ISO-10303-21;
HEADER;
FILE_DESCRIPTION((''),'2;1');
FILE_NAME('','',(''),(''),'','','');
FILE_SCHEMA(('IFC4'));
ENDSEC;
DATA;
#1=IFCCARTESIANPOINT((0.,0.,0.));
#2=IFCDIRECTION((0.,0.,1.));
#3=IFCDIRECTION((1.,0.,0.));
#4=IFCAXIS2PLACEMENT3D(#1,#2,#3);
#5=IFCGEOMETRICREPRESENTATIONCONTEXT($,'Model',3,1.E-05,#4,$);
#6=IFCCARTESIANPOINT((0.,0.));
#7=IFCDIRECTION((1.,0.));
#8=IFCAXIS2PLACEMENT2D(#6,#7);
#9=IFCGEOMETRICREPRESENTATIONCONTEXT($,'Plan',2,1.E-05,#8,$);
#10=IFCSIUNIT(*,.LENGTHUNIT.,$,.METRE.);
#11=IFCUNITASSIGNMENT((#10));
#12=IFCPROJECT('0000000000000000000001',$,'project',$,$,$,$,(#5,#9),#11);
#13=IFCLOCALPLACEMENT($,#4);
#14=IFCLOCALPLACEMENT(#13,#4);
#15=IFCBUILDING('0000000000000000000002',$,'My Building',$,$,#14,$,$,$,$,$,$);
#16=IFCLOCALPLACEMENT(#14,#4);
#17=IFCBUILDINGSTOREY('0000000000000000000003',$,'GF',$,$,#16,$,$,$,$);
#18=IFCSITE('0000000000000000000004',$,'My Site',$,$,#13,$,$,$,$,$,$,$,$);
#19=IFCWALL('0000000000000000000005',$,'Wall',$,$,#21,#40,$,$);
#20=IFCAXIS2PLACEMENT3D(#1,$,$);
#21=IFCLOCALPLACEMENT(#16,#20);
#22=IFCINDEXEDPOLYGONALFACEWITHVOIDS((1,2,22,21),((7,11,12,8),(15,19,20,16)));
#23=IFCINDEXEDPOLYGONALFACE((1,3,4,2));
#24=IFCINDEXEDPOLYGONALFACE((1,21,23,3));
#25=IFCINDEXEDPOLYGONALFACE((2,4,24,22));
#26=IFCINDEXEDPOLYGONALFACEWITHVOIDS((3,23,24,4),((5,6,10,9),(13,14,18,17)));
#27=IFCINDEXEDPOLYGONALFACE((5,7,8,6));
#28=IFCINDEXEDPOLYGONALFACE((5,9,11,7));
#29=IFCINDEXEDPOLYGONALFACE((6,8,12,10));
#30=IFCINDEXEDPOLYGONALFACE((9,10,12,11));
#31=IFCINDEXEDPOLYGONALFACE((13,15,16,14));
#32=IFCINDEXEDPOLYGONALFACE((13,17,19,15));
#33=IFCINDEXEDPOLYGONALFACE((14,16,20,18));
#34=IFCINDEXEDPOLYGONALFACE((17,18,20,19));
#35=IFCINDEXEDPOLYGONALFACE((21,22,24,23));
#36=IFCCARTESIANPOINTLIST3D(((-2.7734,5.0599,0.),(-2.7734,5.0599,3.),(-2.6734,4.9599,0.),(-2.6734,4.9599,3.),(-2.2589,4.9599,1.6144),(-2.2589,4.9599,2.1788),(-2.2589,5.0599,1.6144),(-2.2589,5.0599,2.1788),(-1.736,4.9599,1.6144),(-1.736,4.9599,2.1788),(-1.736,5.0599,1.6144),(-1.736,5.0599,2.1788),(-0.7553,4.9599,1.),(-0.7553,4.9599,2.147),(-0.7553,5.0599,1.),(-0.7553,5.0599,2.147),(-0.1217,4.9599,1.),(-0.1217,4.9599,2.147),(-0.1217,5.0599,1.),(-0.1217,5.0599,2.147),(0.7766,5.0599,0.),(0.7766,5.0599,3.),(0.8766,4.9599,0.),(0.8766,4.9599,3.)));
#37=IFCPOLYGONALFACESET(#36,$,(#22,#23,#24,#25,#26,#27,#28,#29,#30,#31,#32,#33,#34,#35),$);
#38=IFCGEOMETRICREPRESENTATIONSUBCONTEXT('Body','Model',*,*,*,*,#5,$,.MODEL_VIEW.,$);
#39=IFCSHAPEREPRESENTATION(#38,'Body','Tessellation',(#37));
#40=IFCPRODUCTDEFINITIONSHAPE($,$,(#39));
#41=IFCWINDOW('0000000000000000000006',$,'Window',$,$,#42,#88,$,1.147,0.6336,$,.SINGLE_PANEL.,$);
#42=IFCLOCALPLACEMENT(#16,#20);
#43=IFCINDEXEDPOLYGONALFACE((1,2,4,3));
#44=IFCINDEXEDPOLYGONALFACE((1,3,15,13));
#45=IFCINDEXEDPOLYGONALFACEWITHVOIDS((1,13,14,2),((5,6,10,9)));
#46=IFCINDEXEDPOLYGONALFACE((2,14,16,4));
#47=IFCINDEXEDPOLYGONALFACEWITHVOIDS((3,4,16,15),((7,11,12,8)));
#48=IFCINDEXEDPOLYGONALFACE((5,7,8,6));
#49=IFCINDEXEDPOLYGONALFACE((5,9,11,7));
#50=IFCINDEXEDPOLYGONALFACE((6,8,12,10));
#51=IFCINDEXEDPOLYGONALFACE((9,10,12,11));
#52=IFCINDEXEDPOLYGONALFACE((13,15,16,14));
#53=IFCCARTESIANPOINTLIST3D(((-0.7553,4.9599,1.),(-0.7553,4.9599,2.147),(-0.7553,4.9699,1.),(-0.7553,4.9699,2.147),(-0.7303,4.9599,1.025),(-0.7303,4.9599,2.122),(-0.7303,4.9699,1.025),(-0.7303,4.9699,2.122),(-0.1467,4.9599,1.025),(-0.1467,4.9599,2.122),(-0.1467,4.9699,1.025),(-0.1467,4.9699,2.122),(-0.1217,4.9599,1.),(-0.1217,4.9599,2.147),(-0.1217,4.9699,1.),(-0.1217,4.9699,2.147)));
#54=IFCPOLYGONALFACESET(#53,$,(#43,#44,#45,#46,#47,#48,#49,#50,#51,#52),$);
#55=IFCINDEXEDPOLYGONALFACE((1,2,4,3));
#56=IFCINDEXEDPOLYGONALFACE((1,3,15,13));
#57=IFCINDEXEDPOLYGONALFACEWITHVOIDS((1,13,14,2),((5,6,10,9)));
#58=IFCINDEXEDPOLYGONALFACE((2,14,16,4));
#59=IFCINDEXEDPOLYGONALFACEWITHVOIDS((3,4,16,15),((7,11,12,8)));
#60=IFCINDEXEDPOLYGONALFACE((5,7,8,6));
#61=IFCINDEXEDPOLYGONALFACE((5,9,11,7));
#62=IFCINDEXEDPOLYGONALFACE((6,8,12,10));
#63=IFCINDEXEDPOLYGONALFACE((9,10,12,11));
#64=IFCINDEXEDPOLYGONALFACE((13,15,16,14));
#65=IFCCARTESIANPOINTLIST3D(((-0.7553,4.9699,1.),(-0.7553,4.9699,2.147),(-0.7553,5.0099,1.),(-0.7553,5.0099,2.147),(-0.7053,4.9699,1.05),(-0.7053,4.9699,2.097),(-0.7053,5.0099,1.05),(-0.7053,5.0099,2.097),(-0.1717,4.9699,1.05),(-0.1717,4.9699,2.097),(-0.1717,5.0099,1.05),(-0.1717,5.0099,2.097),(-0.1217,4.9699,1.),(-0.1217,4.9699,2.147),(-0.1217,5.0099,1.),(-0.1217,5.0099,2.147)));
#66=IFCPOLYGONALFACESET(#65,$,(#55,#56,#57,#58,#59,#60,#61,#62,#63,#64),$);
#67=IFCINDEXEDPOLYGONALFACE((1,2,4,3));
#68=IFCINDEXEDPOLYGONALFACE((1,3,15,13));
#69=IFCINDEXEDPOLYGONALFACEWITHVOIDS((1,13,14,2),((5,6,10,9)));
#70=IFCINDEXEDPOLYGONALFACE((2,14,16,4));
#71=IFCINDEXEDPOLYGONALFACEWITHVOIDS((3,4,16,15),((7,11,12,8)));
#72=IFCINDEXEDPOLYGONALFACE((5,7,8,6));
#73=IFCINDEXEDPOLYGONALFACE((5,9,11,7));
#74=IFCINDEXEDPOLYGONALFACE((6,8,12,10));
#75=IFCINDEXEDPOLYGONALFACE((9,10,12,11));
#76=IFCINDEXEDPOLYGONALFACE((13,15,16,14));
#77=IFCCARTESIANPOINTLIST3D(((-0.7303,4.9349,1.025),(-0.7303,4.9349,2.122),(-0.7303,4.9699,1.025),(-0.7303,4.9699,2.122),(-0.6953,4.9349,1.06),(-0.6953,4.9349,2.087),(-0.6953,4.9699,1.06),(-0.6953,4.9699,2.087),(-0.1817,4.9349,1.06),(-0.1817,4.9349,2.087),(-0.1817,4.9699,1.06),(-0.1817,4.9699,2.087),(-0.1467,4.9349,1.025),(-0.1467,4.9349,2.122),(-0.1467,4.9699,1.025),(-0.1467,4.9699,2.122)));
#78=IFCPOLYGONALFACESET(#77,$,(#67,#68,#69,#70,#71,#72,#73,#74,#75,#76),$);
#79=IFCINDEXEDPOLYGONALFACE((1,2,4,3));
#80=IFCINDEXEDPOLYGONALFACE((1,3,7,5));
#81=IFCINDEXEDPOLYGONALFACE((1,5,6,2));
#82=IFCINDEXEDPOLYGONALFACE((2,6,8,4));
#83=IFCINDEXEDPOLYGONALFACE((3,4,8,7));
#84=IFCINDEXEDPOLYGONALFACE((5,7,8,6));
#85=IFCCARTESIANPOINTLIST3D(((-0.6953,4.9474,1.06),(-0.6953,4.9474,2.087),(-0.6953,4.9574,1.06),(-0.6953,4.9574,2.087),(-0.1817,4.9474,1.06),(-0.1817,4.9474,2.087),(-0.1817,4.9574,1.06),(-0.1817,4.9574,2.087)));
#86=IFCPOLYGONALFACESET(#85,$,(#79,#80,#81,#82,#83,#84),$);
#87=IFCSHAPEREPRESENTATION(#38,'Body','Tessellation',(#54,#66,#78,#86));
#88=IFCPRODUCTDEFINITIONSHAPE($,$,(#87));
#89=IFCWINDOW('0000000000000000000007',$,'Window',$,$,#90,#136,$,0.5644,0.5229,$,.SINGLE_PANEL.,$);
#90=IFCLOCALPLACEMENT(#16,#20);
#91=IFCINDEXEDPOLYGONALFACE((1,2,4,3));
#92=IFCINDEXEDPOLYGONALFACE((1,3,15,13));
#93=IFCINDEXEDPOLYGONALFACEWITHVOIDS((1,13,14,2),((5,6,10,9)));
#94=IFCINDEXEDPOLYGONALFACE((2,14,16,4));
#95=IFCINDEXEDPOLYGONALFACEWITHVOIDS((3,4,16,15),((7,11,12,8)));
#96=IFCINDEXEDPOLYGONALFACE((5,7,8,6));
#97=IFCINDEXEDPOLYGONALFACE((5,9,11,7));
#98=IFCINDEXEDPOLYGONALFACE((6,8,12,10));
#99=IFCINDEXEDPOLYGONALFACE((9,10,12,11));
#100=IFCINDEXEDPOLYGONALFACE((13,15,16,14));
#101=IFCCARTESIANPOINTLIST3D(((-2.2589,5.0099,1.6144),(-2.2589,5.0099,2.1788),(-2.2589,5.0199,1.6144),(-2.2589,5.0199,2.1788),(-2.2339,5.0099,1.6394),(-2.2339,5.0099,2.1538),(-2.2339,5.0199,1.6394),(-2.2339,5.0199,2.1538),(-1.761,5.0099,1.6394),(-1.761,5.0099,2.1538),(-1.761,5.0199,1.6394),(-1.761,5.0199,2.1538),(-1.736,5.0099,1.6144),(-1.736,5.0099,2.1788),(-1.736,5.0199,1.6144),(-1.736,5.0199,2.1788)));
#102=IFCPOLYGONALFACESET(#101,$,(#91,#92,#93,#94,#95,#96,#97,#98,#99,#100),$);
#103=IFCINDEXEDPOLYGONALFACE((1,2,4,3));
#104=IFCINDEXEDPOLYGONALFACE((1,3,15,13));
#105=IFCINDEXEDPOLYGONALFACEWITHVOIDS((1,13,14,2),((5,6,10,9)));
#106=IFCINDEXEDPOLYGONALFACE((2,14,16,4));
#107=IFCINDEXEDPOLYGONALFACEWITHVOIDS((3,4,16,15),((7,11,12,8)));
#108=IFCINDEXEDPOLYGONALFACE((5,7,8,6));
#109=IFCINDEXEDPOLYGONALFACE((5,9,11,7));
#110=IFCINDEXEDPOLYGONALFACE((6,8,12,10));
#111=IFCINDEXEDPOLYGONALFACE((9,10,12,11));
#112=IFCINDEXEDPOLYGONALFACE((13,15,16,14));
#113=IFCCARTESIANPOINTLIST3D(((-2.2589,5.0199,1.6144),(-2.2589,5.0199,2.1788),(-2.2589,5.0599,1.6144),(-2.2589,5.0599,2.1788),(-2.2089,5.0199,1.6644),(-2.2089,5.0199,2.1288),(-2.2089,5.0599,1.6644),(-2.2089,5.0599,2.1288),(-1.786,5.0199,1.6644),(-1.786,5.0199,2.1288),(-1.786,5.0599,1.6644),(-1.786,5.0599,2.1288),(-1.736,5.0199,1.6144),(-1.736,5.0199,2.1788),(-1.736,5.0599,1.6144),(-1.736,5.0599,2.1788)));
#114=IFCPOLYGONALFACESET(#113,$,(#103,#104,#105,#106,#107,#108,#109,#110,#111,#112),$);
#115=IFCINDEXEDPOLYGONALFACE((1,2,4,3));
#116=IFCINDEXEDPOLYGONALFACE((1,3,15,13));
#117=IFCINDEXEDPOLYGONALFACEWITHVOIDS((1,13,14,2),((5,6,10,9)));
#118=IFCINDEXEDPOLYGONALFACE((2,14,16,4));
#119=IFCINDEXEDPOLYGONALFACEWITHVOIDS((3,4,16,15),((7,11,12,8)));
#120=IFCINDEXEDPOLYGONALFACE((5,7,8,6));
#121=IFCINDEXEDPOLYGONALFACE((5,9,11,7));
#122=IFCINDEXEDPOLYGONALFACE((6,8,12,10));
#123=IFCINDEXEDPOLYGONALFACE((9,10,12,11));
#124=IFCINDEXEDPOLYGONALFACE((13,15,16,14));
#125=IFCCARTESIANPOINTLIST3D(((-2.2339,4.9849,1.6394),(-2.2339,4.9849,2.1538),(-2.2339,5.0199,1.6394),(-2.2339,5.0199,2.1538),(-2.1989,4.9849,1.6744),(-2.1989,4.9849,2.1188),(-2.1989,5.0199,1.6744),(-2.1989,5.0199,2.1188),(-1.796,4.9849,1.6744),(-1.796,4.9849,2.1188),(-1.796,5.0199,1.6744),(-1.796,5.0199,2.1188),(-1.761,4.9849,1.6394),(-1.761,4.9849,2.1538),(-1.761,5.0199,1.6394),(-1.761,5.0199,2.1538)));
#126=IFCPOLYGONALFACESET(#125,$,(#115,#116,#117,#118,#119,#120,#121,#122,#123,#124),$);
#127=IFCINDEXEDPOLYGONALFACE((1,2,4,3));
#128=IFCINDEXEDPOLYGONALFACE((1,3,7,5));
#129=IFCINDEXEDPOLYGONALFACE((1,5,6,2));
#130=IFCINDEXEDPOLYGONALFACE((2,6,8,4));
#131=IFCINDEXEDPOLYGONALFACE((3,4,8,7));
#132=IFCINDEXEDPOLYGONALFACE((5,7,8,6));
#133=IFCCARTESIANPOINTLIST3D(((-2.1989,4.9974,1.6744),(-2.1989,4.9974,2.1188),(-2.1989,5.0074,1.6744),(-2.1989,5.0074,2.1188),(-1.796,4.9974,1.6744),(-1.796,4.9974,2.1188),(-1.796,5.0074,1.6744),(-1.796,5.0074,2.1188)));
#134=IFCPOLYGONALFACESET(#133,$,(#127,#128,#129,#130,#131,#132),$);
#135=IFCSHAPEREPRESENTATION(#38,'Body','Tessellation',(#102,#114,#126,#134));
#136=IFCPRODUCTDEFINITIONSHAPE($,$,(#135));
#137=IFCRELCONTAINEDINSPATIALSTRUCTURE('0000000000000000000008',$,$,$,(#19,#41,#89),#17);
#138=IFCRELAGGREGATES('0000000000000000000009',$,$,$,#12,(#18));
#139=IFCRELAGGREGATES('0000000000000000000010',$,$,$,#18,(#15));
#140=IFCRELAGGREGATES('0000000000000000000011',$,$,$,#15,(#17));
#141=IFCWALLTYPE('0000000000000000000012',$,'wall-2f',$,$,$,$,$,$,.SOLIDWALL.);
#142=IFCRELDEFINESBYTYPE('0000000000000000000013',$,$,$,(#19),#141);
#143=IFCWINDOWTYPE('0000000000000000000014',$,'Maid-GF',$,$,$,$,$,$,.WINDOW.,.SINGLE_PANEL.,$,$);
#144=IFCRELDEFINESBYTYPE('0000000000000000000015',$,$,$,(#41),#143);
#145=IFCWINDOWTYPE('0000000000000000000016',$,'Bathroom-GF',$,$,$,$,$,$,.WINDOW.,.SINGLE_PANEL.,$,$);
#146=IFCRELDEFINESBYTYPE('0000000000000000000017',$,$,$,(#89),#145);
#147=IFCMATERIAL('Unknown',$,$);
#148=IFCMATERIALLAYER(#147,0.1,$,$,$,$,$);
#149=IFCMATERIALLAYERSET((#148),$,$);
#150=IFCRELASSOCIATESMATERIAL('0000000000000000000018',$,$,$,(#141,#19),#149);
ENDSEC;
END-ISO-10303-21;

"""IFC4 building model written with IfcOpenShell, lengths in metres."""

from ifc_helpers import new_model, entity, si_unit, frame, origin_with_axes, origin_2d_with_axis, place, context, subcontext, project, spatial, line, indexed_curve, outline, extrude, shape, source, transform, mapped, material, layer, layer_set, layer_usage, type_object, type_shapes, element, fill, save


model = new_model("IFC4")

# Units and contexts
model_context = context("Model", 3, precision=1e-05, world=origin_with_axes())
plan_context = context("Plan", 2, precision=1e-05, world=origin_2d_with_axis())
body_context_1 = subcontext(model_context, "Body", "Model", "MODEL_VIEW")
body_context_2 = subcontext(plan_context, "Body", "Plan", "PLAN_VIEW")
ifc_project = project(units=[si_unit("LENGTHUNIT", "METRE")], contexts=[model_context, plan_context])

# Site, building, storey
site_placement = place(None, origin_with_axes())
site = spatial("IfcSite", under=ifc_project, at=site_placement, Name="My Site")
building_placement = place(site_placement, origin_with_axes())
building = spatial("IfcBuilding", under=site, at=building_placement, Name="My Building")
storey_placement = place(building_placement, origin_with_axes())
storey = spatial("IfcBuildingStorey", under=building, at=storey_placement, Name="GF")

# Shared definitions
ifc_material = material(Name="Unknown")

# Shared definitions
ifc_layer_1 = layer(ifc_material, 0.1)
ifc_layer_set_1 = layer_set([ifc_layer_1])
wall_type = type_object("IfcWallType", Name="wall-2f", PredefinedType="SOLIDWALL", material=ifc_layer_set_1)

# Wall, openings, windows
ifc_layer_usage_1 = layer_usage(ifc_layer_set_1, "AXIS2", "POSITIVE", 0.0)
wall_1_placement = place(storey_placement, frame((0.7766, 5.0599, 0.0), z_axis=(0.0, 0.0, 1.0), x_axis=(-1.0, 0.0, 0.0)))
wall_1 = element("IfcWall", 1, at=wall_1_placement, inside=storey, type_object=wall_type, material=ifc_layer_usage_1, Name="Wall", context=body_context_1, shape_type="SweptSolid", body=[
    extrude(outline(indexed_curve([(0.0, 0.0), (-0.1, 0.1), (3.45, 0.1), (3.55, 0.0)], segments=[line(1, 2, 3, 4, 1)])), origin_with_axes(), (0.0, 0.0, 1.0), 3.0),
])
shared_shape_1 = source(origin_with_axes(), body_context_1, "Body", "SweptSolid", [
    extrude(outline(indexed_curve([(0.0, 0.0), (0.6336, 0.0), (0.6336, 1.147), (0.0, 1.147)], segments=[line(1, 2, 3, 4, 1)])), frame((0.0, -0.6, 0.0), z_axis=(0.0, -1.0, 0.0), x_axis=(1.0, 0.0, 0.0)), (0.0, 0.0, -1.0), 1.2),
])
opening_1_placement = place(wall_1_placement, frame((0.8983, 0.0, 1.0), z_axis=(0.0, 0.0, 1.0), x_axis=(1.0, 0.0, 0.0)))
opening_1 = element("IfcOpeningElement", 2, at=opening_1_placement, cuts=wall_1, PredefinedType="OPENING", context=body_context_1, shape_type="MappedRepresentation", body=[
    mapped(shared_shape_1, transform((0.0, 0.0, 0.0), x_axis=(1.0, 0.0, 0.0), y_axis=(0.0, 1.0, 0.0), z_axis=(0.0, 0.0, 1.0), scale=1.0)),
])
shared_shape_2 = source(origin_with_axes(), body_context_1, "Body", "SweptSolid", [
    extrude(outline(indexed_curve([(0.0, 0.0), (0.5229, 0.0), (0.5229, 0.5644), (0.0, 0.5644)], segments=[line(1, 2, 3, 4, 1)])), frame((0.0, -0.6, 0.0), z_axis=(0.0, -1.0, 0.0), x_axis=(1.0, 0.0, 0.0)), (0.0, 0.0, -1.0), 1.2),
])
opening_2_placement = place(wall_1_placement, frame((2.5126, -0.05, 1.6144), z_axis=(0.0, 0.0, 1.0), x_axis=(1.0, 0.0, 0.0)))
opening_2 = element("IfcOpeningElement", 3, at=opening_2_placement, cuts=wall_1, PredefinedType="OPENING", context=body_context_1, shape_type="MappedRepresentation", body=[
    mapped(shared_shape_2, transform((0.0, 0.0, 0.0), x_axis=(1.0, 0.0, 0.0), y_axis=(0.0, 1.0, 0.0), z_axis=(0.0, 0.0, 1.0), scale=1.0)),
])
window_type_1 = type_object("IfcWindowType", Name="Maid-GF", PartitioningType="SINGLE_PANEL", PredefinedType="WINDOW")
shared_shape_3 = source(origin_with_axes(), body_context_1, "Body", "SweptSolid", [
    extrude(outline(indexed_curve([(0.0, 0.0), (0.6336, 0.0), (0.6336, 1.147), (0.0, 1.147)], segments=[line(1, 2, 3, 4, 1)]), holes=[indexed_curve([(0.025, 0.025), (0.6086, 0.025), (0.6086, 1.122), (0.025, 1.122)], segments=[line(1, 2, 3, 4, 1)])]), frame((0.0, 0.09, 0.0), z_axis=(0.0, -1.0, 0.0), x_axis=(1.0, 0.0, 0.0)), (0.0, 0.0, -1.0), 0.01),
    extrude(outline(indexed_curve([(0.0, 0.0), (0.6336, 0.0), (0.6336, 1.147), (0.0, 1.147)], segments=[line(1, 2, 3, 4, 1)]), holes=[indexed_curve([(0.05, 0.05), (0.5836, 0.05), (0.5836, 1.097), (0.05, 1.097)], segments=[line(1, 2, 3, 4, 1)])]), frame((0.0, 0.05, 0.0), z_axis=(0.0, -1.0, 0.0), x_axis=(1.0, 0.0, 0.0)), (0.0, 0.0, -1.0), 0.04),
    extrude(outline(indexed_curve([(0.0, 0.0), (0.5836, 0.0), (0.5836, 1.097), (0.0, 1.097)], segments=[line(1, 2, 3, 4, 1)]), holes=[indexed_curve([(0.035, 0.035), (0.5486, 0.035), (0.5486, 1.062), (0.035, 1.062)], segments=[line(1, 2, 3, 4, 1)])]), frame((0.025, 0.09, 0.025), z_axis=(0.0, -1.0, 0.0), x_axis=(1.0, 0.0, 0.0)), (0.0, 0.0, -1.0), 0.035),
    extrude(outline(indexed_curve([(0.035, 0.035), (0.5486, 0.035), (0.5486, 1.062), (0.035, 1.062)], segments=[line(1, 2, 3, 4, 1)])), frame((0.025, 0.1025, 0.025), z_axis=(0.0, -1.0, 0.0), x_axis=(1.0, 0.0, 0.0)), (0.0, 0.0, -1.0), 0.01),
])
shared_shape_4 = source(origin_with_axes(), body_context_2, "Body", "Curve2D", [
    entity("IfcIndexedPolyCurve", entity("IfcCartesianPointList2D", [[0.05, 0.05], [0.5836, 0.05]])),
    entity("IfcIndexedPolyCurve", entity("IfcCartesianPointList2D", [[0.0, 0.1], [0.025, 0.1], [0.025, 0.09], [0.05, 0.09], [0.05, 0.05], [0.0, 0.05]]), [entity("IfcLineIndex", [1, 2, 3, 4, 5, 6, 1])]),
    entity("IfcIndexedPolyCurve", entity("IfcCartesianPointList2D", [[0.6336, 0.1], [0.6086, 0.1], [0.6086, 0.09], [0.5836, 0.09], [0.5836, 0.05], [0.6336, 0.05]]), [entity("IfcLineIndex", [1, 2, 3, 4, 5, 6, 1])]),
    entity("IfcIndexedPolyCurve", entity("IfcCartesianPointList2D", [[0.025, 0.09], [0.06, 0.09], [0.06, 0.125], [0.025, 0.125]]), [entity("IfcLineIndex", [1, 2, 3, 4, 1])]),
    entity("IfcIndexedPolyCurve", entity("IfcCartesianPointList2D", [[0.6086, 0.09], [0.5736, 0.09], [0.5736, 0.125], [0.6086, 0.125]]), [entity("IfcLineIndex", [1, 2, 3, 4, 1])]),
    entity("IfcIndexedPolyCurve", entity("IfcCartesianPointList2D", [[0.06, 0.09], [0.5736, 0.09]])),
    entity("IfcIndexedPolyCurve", entity("IfcCartesianPointList2D", [[0.06, 0.125], [0.5736, 0.125]])),
    entity("IfcIndexedPolyCurve", entity("IfcCartesianPointList2D", [[0.06, 0.1075], [0.5736, 0.1075]])),
])
type_shapes(window_type_1, [shared_shape_3, shared_shape_4])
window_1_placement = place(opening_1_placement, frame((0.0, 0.0, 0.0), z_axis=(0.0, 0.0, 1.0), x_axis=(1.0, 0.0, 0.0)))
window_1 = element("IfcWindow", 4, at=window_1_placement, inside=storey, type_object=window_type_1, Name="Window", OverallHeight=1.147, OverallWidth=0.6336, PartitioningType="SINGLE_PANEL", shapes=[
    shape(body_context_1, "Body", "MappedRepresentation", [mapped(shared_shape_3, transform((0.0, 0.0, 0.0), x_axis=(1.0, 0.0, 0.0), y_axis=(0.0, 1.0, 0.0), z_axis=(0.0, 0.0, 1.0), scale=1.0))]),
    shape(body_context_2, "Body", "MappedRepresentation", [mapped(shared_shape_4, transform((0.0, 0.0, 0.0), x_axis=(1.0, 0.0, 0.0), y_axis=(0.0, 1.0, 0.0), z_axis=(0.0, 0.0, 1.0), scale=1.0))]),
])
fill(opening_1, window_1)
window_type_2 = type_object("IfcWindowType", Name="Bathroom-GF", PartitioningType="SINGLE_PANEL", PredefinedType="WINDOW")
shared_shape_5 = source(origin_with_axes(), body_context_1, "Body", "SweptSolid", [
    extrude(outline(indexed_curve([(0.0, 0.0), (0.5229, 0.0), (0.5229, 0.5644), (0.0, 0.5644)], segments=[line(1, 2, 3, 4, 1)]), holes=[indexed_curve([(0.025, 0.025), (0.4979, 0.025), (0.4979, 0.5394), (0.025, 0.5394)], segments=[line(1, 2, 3, 4, 1)])]), frame((0.0, 0.09, 0.0), z_axis=(0.0, -1.0, 0.0), x_axis=(1.0, 0.0, 0.0)), (0.0, 0.0, -1.0), 0.01),
    extrude(outline(indexed_curve([(0.0, 0.0), (0.5229, 0.0), (0.5229, 0.5644), (0.0, 0.5644)], segments=[line(1, 2, 3, 4, 1)]), holes=[indexed_curve([(0.05, 0.05), (0.4729, 0.05), (0.4729, 0.5144), (0.05, 0.5144)], segments=[line(1, 2, 3, 4, 1)])]), frame((0.0, 0.05, 0.0), z_axis=(0.0, -1.0, 0.0), x_axis=(1.0, 0.0, 0.0)), (0.0, 0.0, -1.0), 0.04),
    extrude(outline(indexed_curve([(0.0, 0.0), (0.4729, 0.0), (0.4729, 0.5144), (0.0, 0.5144)], segments=[line(1, 2, 3, 4, 1)]), holes=[indexed_curve([(0.035, 0.035), (0.4379, 0.035), (0.4379, 0.4794), (0.035, 0.4794)], segments=[line(1, 2, 3, 4, 1)])]), frame((0.025, 0.09, 0.025), z_axis=(0.0, -1.0, 0.0), x_axis=(1.0, 0.0, 0.0)), (0.0, 0.0, -1.0), 0.035),
    extrude(outline(indexed_curve([(0.035, 0.035), (0.4379, 0.035), (0.4379, 0.4794), (0.035, 0.4794)], segments=[line(1, 2, 3, 4, 1)])), frame((0.025, 0.1025, 0.025), z_axis=(0.0, -1.0, 0.0), x_axis=(1.0, 0.0, 0.0)), (0.0, 0.0, -1.0), 0.01),
])
shared_shape_6 = source(origin_with_axes(), body_context_2, "Body", "Curve2D", [
    entity("IfcIndexedPolyCurve", entity("IfcCartesianPointList2D", [[0.05, 0.05], [0.4729, 0.05]])),
    entity("IfcIndexedPolyCurve", entity("IfcCartesianPointList2D", [[0.0, 0.1], [0.025, 0.1], [0.025, 0.09], [0.05, 0.09], [0.05, 0.05], [0.0, 0.05]]), [entity("IfcLineIndex", [1, 2, 3, 4, 5, 6, 1])]),
    entity("IfcIndexedPolyCurve", entity("IfcCartesianPointList2D", [[0.5229, 0.1], [0.4979, 0.1], [0.4979, 0.09], [0.4729, 0.09], [0.4729, 0.05], [0.5229, 0.05]]), [entity("IfcLineIndex", [1, 2, 3, 4, 5, 6, 1])]),
    entity("IfcIndexedPolyCurve", entity("IfcCartesianPointList2D", [[0.025, 0.09], [0.06, 0.09], [0.06, 0.125], [0.025, 0.125]]), [entity("IfcLineIndex", [1, 2, 3, 4, 1])]),
    entity("IfcIndexedPolyCurve", entity("IfcCartesianPointList2D", [[0.4979, 0.09], [0.4629, 0.09], [0.4629, 0.125], [0.4979, 0.125]]), [entity("IfcLineIndex", [1, 2, 3, 4, 1])]),
    entity("IfcIndexedPolyCurve", entity("IfcCartesianPointList2D", [[0.06, 0.09], [0.4629, 0.09]])),
    entity("IfcIndexedPolyCurve", entity("IfcCartesianPointList2D", [[0.06, 0.125], [0.4629, 0.125]])),
    entity("IfcIndexedPolyCurve", entity("IfcCartesianPointList2D", [[0.06, 0.1075], [0.4629, 0.1075]])),
])
type_shapes(window_type_2, [shared_shape_5, shared_shape_6])
window_2_placement = place(opening_2_placement, frame((0.0, 0.0, 0.0), z_axis=(0.0, 0.0, 1.0), x_axis=(1.0, 0.0, 0.0)))
window_2 = element("IfcWindow", 5, at=window_2_placement, inside=storey, type_object=window_type_2, Name="Window", OverallHeight=0.5644, OverallWidth=0.5229, PartitioningType="SINGLE_PANEL", shapes=[
    shape(body_context_1, "Body", "MappedRepresentation", [mapped(shared_shape_5, transform((0.0, 0.0, 0.0), x_axis=(1.0, 0.0, 0.0), y_axis=(0.0, 1.0, 0.0), z_axis=(0.0, 0.0, 1.0), scale=1.0))]),
    shape(body_context_2, "Body", "MappedRepresentation", [mapped(shared_shape_6, transform((0.0, 0.0, 0.0), x_axis=(1.0, 0.0, 0.0), y_axis=(0.0, 1.0, 0.0), z_axis=(0.0, 0.0, 1.0), scale=1.0))]),
])
fill(opening_2, window_2)

save(model, "model.ifc")
